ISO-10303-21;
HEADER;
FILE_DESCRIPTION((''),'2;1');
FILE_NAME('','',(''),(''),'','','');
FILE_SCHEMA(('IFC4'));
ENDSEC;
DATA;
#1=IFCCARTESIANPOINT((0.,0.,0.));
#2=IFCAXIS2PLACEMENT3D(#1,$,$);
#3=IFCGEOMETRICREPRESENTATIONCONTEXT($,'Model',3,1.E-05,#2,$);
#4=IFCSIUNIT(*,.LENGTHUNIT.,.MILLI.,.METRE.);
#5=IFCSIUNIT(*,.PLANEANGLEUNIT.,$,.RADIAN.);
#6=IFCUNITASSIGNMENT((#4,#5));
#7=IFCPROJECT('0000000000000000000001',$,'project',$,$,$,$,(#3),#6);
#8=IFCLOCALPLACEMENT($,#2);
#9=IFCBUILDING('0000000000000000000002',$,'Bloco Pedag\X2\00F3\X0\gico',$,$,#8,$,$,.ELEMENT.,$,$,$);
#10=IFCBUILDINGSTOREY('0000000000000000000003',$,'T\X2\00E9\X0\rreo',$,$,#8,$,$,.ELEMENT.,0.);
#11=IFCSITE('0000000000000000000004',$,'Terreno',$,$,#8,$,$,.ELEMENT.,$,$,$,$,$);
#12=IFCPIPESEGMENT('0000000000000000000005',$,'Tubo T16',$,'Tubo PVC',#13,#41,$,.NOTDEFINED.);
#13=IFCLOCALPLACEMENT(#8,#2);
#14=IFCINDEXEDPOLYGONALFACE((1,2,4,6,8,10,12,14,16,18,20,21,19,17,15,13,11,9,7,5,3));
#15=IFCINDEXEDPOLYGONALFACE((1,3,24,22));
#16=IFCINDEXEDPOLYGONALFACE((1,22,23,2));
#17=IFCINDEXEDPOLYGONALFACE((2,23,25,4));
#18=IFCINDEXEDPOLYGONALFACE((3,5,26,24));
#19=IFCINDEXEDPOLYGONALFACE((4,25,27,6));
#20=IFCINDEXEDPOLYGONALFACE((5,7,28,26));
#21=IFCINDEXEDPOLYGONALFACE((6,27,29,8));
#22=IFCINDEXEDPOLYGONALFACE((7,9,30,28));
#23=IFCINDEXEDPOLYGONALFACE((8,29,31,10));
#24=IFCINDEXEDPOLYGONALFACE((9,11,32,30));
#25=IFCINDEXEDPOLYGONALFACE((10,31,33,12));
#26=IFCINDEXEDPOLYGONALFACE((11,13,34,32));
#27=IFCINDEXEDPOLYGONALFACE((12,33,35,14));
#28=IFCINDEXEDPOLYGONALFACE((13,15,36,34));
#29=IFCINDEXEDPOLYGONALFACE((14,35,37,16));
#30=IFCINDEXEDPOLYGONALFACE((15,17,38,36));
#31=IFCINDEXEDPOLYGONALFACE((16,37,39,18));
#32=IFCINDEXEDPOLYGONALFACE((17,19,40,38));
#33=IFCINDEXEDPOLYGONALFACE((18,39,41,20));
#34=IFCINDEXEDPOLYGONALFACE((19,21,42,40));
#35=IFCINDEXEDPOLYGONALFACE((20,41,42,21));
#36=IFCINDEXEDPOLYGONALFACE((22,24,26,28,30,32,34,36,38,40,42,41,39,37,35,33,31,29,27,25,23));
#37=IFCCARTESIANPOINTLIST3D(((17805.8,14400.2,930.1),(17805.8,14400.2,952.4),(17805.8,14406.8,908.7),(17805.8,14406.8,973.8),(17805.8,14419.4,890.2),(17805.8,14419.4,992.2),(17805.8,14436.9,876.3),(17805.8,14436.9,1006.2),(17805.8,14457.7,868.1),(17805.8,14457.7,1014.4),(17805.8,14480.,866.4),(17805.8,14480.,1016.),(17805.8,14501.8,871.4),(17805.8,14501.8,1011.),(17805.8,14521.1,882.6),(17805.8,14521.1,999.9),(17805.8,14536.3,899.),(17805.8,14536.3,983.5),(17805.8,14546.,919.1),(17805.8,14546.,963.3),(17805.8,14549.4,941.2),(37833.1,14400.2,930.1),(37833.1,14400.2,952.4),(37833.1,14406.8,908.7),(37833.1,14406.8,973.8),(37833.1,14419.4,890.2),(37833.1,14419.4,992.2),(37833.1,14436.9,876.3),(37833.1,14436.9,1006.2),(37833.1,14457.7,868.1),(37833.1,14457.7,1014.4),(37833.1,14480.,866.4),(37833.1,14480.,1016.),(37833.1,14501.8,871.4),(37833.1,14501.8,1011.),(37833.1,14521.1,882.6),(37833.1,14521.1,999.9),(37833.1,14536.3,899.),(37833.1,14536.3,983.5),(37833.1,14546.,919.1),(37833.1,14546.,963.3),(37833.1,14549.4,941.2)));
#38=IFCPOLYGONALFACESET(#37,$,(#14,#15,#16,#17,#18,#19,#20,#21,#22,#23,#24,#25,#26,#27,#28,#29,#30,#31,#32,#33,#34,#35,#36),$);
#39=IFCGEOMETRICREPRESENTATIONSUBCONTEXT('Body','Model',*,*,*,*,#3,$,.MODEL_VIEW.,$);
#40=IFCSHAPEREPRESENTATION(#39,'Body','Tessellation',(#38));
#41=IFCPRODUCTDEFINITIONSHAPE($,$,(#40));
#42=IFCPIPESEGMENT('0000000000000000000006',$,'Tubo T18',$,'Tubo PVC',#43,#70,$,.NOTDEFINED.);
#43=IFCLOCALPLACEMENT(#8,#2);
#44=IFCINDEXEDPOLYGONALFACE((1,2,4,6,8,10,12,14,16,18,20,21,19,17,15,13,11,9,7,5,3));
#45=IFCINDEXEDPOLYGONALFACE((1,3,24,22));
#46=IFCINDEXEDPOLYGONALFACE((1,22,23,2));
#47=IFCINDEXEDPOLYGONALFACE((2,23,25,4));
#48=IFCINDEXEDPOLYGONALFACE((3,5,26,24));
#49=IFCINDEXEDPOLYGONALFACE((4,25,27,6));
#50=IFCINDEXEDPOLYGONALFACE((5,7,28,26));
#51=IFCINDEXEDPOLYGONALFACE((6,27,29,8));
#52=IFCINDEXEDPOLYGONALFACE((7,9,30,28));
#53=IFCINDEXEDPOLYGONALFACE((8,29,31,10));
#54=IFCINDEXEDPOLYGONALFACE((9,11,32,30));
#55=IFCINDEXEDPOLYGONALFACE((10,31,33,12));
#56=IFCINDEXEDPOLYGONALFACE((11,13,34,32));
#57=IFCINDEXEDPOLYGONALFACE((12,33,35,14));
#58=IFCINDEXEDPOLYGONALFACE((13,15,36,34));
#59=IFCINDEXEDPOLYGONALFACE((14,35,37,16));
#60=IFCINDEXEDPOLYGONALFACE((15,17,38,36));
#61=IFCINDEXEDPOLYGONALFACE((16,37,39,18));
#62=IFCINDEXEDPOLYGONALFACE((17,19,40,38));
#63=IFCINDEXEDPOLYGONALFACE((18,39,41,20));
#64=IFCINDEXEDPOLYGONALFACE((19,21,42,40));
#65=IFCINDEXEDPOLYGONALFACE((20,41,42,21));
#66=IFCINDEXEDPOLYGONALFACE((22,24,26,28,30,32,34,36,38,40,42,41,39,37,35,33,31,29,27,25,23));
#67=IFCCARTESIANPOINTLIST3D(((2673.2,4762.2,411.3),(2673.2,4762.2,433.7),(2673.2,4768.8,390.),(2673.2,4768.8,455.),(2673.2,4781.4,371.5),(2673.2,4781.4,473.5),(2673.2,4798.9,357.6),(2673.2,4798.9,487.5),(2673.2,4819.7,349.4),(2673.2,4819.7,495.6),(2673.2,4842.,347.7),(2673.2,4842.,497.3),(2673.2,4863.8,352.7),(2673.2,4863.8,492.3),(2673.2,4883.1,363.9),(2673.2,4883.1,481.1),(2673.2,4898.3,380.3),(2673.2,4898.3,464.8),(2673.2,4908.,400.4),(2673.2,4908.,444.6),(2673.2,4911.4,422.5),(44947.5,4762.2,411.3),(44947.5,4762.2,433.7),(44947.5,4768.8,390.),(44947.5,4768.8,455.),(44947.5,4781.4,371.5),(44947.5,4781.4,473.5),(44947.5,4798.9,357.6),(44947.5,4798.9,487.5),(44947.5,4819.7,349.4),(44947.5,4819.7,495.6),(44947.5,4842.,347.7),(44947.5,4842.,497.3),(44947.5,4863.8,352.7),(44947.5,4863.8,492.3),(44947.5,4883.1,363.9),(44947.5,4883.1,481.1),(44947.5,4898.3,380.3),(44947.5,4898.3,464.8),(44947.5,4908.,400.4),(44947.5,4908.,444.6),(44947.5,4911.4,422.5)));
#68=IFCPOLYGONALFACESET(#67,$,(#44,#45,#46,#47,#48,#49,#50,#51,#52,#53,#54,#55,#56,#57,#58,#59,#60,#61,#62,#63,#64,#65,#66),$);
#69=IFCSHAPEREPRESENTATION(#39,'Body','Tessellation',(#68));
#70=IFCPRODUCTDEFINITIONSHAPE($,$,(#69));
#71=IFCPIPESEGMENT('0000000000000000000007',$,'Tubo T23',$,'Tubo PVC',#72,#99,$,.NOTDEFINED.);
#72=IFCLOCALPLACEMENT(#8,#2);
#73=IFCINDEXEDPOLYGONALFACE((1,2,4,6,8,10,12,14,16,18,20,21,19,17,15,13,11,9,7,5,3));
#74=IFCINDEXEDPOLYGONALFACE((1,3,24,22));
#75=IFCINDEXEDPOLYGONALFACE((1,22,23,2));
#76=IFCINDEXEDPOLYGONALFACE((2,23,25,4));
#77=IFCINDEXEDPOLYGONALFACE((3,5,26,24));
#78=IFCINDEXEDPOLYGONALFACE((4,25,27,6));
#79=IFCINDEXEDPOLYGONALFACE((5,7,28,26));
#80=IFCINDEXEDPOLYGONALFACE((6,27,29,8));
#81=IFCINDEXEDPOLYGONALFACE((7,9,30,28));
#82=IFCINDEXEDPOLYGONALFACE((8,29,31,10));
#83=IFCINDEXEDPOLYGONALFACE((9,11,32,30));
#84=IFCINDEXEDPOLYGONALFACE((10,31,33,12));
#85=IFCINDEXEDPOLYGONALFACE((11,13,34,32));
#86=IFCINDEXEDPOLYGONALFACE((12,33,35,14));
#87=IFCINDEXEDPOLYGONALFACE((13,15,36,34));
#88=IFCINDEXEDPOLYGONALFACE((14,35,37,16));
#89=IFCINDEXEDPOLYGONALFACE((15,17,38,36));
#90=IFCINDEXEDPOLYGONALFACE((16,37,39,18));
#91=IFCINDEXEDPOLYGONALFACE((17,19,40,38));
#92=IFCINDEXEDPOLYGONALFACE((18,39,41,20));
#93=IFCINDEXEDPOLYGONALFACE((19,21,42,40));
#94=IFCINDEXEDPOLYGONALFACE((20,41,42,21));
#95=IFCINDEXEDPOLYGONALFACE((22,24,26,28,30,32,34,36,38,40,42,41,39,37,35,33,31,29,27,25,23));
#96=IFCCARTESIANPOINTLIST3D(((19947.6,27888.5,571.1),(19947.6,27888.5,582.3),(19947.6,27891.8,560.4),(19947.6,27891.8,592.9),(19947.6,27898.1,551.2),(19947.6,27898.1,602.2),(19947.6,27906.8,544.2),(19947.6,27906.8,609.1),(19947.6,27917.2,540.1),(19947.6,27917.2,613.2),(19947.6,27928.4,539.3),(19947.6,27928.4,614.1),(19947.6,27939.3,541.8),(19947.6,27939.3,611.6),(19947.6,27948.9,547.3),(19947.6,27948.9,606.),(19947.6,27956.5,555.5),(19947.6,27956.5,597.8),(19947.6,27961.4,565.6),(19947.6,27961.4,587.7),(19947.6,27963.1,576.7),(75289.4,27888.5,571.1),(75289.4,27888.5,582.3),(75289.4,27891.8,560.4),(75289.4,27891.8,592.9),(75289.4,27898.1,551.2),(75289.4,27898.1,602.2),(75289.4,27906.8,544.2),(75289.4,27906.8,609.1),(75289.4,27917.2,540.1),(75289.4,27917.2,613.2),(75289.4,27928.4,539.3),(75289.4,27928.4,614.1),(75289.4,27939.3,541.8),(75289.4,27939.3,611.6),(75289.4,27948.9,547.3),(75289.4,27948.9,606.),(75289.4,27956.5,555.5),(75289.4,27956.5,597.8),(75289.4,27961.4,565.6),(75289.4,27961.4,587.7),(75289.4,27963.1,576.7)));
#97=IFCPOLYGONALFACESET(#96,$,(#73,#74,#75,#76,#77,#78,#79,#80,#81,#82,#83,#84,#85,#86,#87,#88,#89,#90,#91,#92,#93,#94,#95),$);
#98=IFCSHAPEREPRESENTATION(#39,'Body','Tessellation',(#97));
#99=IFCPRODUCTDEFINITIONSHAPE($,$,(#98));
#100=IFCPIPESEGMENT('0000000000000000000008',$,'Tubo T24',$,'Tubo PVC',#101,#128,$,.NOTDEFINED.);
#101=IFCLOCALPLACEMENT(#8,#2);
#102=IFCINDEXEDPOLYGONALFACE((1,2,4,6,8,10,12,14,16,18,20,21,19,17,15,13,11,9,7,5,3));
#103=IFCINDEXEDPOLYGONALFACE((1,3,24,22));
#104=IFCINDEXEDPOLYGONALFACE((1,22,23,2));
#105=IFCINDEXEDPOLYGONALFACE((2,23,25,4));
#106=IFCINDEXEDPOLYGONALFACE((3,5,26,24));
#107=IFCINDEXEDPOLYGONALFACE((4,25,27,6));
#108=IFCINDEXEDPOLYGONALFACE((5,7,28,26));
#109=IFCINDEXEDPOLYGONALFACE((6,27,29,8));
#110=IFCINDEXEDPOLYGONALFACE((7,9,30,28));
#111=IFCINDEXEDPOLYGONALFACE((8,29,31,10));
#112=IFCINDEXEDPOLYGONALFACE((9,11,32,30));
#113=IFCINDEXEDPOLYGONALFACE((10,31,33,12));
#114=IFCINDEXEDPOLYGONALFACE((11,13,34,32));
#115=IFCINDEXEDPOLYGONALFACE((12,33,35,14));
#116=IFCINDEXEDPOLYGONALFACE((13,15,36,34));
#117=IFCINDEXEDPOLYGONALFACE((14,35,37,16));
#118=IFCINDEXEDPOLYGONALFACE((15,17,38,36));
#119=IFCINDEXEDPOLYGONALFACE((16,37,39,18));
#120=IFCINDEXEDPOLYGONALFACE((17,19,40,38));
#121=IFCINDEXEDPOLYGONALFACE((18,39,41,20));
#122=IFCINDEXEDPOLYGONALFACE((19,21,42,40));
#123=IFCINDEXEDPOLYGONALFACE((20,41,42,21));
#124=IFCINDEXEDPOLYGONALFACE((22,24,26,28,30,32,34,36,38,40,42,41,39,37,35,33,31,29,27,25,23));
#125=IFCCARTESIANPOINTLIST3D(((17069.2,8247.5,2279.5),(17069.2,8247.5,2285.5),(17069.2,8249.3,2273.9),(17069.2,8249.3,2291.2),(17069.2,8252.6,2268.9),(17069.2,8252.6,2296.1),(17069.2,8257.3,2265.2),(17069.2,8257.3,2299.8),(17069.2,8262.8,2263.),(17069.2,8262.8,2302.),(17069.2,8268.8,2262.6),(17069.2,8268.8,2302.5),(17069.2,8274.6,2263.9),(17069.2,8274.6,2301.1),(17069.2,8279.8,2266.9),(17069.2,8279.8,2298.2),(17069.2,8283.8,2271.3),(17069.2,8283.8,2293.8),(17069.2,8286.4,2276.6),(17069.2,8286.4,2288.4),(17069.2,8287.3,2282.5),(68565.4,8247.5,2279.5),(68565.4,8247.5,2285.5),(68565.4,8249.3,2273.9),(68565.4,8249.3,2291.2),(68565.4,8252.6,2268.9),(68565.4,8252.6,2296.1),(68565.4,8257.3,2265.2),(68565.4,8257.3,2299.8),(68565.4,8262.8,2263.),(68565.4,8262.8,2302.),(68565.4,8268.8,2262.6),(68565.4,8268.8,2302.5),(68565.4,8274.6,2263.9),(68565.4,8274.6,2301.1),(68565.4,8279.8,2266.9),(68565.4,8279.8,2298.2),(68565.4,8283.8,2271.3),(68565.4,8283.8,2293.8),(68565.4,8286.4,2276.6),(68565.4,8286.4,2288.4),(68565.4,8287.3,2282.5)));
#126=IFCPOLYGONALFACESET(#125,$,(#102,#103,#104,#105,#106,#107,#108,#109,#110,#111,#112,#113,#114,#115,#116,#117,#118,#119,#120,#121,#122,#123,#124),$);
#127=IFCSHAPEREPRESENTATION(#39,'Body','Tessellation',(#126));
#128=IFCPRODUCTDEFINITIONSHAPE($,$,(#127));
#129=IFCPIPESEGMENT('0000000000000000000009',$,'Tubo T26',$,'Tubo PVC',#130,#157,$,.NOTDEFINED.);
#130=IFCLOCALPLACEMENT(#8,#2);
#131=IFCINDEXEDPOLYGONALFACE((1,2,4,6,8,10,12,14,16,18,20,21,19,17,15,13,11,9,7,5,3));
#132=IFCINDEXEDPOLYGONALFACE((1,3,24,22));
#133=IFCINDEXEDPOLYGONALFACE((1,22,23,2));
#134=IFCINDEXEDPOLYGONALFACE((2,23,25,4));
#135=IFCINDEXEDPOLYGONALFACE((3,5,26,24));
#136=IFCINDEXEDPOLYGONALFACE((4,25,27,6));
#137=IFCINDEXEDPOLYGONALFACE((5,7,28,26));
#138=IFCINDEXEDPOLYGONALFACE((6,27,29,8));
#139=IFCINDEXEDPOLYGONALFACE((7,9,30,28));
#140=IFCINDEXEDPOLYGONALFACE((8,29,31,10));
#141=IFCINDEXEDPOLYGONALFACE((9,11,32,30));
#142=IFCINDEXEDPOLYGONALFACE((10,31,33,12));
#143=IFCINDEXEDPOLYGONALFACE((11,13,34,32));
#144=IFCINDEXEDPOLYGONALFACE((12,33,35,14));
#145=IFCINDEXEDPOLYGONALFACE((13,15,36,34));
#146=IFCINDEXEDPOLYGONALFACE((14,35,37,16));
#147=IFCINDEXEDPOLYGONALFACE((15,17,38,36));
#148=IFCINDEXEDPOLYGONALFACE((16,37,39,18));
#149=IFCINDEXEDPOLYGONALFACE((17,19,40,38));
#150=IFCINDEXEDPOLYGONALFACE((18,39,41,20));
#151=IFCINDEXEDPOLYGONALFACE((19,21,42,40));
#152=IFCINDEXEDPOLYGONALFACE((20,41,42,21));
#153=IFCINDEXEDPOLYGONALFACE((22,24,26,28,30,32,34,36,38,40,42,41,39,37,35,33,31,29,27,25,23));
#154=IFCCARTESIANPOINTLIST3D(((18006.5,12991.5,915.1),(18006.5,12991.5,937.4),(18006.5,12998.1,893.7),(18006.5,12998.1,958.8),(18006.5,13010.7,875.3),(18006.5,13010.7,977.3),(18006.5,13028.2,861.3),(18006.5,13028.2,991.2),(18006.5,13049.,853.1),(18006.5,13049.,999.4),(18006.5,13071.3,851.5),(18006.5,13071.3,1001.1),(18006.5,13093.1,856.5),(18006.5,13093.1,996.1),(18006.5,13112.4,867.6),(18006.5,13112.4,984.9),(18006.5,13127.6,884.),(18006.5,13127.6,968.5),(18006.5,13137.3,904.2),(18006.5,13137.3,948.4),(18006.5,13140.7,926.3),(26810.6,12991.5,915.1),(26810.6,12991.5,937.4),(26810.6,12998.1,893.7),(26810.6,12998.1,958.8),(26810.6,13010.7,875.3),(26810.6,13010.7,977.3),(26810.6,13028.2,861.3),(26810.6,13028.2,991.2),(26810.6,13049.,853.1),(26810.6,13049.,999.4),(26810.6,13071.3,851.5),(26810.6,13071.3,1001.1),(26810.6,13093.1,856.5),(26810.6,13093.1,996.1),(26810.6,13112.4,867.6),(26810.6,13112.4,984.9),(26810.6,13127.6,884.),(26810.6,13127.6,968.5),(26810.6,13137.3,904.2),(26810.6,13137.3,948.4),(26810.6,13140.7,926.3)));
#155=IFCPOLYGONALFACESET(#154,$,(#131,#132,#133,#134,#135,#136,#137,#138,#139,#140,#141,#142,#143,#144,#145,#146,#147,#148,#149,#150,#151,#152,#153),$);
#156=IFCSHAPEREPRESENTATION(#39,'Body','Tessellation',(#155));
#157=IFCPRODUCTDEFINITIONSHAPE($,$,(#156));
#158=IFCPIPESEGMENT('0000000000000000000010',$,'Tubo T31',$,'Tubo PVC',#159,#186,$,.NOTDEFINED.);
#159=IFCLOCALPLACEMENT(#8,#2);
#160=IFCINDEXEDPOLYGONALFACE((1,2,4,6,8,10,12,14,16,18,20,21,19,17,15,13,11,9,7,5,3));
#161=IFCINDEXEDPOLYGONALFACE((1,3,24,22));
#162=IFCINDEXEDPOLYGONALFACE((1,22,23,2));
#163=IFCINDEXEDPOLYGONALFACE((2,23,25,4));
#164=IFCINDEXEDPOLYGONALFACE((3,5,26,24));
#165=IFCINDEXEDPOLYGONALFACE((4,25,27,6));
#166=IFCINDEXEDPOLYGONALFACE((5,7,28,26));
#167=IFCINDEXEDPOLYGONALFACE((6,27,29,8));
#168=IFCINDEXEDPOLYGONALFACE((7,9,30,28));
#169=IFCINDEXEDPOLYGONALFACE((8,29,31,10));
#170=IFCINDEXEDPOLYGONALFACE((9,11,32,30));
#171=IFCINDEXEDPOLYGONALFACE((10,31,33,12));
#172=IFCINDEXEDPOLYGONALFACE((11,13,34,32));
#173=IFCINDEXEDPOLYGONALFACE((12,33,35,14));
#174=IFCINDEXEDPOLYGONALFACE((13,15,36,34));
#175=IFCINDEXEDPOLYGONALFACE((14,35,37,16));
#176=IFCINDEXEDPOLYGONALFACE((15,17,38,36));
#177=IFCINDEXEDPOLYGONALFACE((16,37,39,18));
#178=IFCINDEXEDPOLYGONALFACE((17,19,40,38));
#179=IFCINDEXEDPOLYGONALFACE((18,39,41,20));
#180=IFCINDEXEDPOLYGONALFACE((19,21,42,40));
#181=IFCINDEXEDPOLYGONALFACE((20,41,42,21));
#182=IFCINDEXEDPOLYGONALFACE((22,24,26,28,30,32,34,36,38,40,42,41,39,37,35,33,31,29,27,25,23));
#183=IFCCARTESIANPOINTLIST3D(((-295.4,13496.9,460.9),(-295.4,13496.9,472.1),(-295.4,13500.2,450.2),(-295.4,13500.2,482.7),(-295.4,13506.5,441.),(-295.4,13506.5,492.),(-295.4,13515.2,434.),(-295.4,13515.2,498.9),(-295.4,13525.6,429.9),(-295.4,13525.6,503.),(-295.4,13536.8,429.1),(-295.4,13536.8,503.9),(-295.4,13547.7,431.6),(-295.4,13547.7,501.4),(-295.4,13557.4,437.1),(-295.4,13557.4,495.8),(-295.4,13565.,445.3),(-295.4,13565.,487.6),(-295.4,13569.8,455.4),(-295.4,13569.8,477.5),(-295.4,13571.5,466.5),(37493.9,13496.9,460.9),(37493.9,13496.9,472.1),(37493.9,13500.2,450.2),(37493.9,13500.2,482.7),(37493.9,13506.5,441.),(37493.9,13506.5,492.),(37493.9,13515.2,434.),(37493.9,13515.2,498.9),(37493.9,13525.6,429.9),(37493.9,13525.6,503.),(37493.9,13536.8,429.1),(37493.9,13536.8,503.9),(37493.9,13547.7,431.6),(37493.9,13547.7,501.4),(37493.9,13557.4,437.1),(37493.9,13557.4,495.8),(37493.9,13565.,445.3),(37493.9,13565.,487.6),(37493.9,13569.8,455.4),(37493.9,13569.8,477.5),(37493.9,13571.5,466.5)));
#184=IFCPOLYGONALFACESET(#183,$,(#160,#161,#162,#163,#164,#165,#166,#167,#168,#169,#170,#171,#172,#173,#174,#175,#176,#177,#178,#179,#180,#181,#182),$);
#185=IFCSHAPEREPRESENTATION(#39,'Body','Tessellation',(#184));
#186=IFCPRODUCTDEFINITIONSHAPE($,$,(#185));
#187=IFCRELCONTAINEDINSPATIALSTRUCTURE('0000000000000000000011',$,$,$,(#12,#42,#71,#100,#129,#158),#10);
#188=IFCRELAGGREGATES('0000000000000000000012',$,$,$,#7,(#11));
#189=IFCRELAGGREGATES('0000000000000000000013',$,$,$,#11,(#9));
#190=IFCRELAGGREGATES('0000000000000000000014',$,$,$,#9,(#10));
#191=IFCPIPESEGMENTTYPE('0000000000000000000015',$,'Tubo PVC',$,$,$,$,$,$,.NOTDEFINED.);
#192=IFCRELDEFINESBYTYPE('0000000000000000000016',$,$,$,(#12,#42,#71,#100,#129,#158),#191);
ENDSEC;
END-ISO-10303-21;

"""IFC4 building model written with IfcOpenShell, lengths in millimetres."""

from ifc_helpers import new_model, si_unit, frame, origin, origin_2d, place, context, subcontext, project, spatial, circle, extrude, type_object, element, save


model = new_model("IFC4")

# Units and contexts
model_context = context("Model", 3, precision=1e-05, world=origin())
body_context = subcontext(model_context, "Body", "Model", "MODEL_VIEW")
ifc_project = project(units=[si_unit("LENGTHUNIT", "METRE", prefix="MILLI"), si_unit("PLANEANGLEUNIT", "RADIAN")], contexts=[model_context])

# Site, building, storey
placement = place(None, origin())
site = spatial("IfcSite", under=ifc_project, at=placement, Name="Terreno", CompositionType="ELEMENT")
building = spatial("IfcBuilding", under=site, at=placement, Name="Bloco Pedagógico", CompositionType="ELEMENT")
storey = spatial("IfcBuildingStorey", under=building, at=placement, Name="Térreo", CompositionType="ELEMENT", Elevation=0.0)

# Pipe segments
pipe_segment_type = type_object("IfcPipeSegmentType", Name="Tubo PVC", PredefinedType="NOTDEFINED")
pipe_segment_1_placement = place(None, frame((17805.8, 14474.4, 941.2), z_axis=(1.0, 0.0, 0.0), x_axis=(0.0, 1.0, 0.0)))
element("IfcPipeSegment", 1, at=pipe_segment_1_placement, inside=storey, type_object=pipe_segment_type, Name="Tubo T16", ObjectType="Tubo PVC", PredefinedType="NOTDEFINED", context=body_context, shape_type="SweptSolid", body=[
    extrude(circle(Radius=75.0, at=origin_2d()), None, (0.0, 0.0, 1.0), 20027.2),
])
pipe_segment_2_placement = place(None, frame((2673.2, 4836.4, 422.5), z_axis=(1.0, 0.0, 0.0), x_axis=(0.0, 1.0, 0.0)))
element("IfcPipeSegment", 2, at=pipe_segment_2_placement, inside=storey, type_object=pipe_segment_type, Name="Tubo T18", ObjectType="Tubo PVC", PredefinedType="NOTDEFINED", context=body_context, shape_type="SweptSolid", body=[
    extrude(circle(Radius=75.0, at=origin_2d()), None, (0.0, 0.0, 1.0), 42274.2),
])
pipe_segment_3_placement = place(None, frame((19947.6, 27925.6, 576.7), z_axis=(1.0, 0.0, 0.0), x_axis=(0.0, 1.0, 0.0)))
element("IfcPipeSegment", 3, at=pipe_segment_3_placement, inside=storey, type_object=pipe_segment_type, Name="Tubo T23", ObjectType="Tubo PVC", PredefinedType="NOTDEFINED", context=body_context, shape_type="SweptSolid", body=[
    extrude(circle(Radius=37.5, at=origin_2d()), None, (0.0, 0.0, 1.0), 55341.8),
])
pipe_segment_4_placement = place(None, frame((17069.2, 8267.3, 2282.5), z_axis=(1.0, 0.0, 0.0), x_axis=(0.0, 1.0, 0.0)))
element("IfcPipeSegment", 4, at=pipe_segment_4_placement, inside=storey, type_object=pipe_segment_type, Name="Tubo T24", ObjectType="Tubo PVC", PredefinedType="NOTDEFINED", context=body_context, shape_type="SweptSolid", body=[
    extrude(circle(Radius=20.0, at=origin_2d()), None, (0.0, 0.0, 1.0), 51496.2),
])
pipe_segment_5_placement = place(None, frame((18006.5, 13065.7, 926.3), z_axis=(1.0, 0.0, 0.0), x_axis=(0.0, 1.0, 0.0)))
element("IfcPipeSegment", 5, at=pipe_segment_5_placement, inside=storey, type_object=pipe_segment_type, Name="Tubo T26", ObjectType="Tubo PVC", PredefinedType="NOTDEFINED", context=body_context, shape_type="SweptSolid", body=[
    extrude(circle(Radius=75.0, at=origin_2d()), None, (0.0, 0.0, 1.0), 8804.2),
])
pipe_segment_6_placement = place(None, frame((-295.4, 13534.0, 466.5), z_axis=(1.0, 0.0, 0.0), x_axis=(0.0, 1.0, 0.0)))
element("IfcPipeSegment", 6, at=pipe_segment_6_placement, inside=storey, type_object=pipe_segment_type, Name="Tubo T31", ObjectType="Tubo PVC", PredefinedType="NOTDEFINED", context=body_context, shape_type="SweptSolid", body=[
    extrude(circle(Radius=37.5, at=origin_2d()), None, (0.0, 0.0, 1.0), 37789.2),
])

save(model, "model.ifc")
